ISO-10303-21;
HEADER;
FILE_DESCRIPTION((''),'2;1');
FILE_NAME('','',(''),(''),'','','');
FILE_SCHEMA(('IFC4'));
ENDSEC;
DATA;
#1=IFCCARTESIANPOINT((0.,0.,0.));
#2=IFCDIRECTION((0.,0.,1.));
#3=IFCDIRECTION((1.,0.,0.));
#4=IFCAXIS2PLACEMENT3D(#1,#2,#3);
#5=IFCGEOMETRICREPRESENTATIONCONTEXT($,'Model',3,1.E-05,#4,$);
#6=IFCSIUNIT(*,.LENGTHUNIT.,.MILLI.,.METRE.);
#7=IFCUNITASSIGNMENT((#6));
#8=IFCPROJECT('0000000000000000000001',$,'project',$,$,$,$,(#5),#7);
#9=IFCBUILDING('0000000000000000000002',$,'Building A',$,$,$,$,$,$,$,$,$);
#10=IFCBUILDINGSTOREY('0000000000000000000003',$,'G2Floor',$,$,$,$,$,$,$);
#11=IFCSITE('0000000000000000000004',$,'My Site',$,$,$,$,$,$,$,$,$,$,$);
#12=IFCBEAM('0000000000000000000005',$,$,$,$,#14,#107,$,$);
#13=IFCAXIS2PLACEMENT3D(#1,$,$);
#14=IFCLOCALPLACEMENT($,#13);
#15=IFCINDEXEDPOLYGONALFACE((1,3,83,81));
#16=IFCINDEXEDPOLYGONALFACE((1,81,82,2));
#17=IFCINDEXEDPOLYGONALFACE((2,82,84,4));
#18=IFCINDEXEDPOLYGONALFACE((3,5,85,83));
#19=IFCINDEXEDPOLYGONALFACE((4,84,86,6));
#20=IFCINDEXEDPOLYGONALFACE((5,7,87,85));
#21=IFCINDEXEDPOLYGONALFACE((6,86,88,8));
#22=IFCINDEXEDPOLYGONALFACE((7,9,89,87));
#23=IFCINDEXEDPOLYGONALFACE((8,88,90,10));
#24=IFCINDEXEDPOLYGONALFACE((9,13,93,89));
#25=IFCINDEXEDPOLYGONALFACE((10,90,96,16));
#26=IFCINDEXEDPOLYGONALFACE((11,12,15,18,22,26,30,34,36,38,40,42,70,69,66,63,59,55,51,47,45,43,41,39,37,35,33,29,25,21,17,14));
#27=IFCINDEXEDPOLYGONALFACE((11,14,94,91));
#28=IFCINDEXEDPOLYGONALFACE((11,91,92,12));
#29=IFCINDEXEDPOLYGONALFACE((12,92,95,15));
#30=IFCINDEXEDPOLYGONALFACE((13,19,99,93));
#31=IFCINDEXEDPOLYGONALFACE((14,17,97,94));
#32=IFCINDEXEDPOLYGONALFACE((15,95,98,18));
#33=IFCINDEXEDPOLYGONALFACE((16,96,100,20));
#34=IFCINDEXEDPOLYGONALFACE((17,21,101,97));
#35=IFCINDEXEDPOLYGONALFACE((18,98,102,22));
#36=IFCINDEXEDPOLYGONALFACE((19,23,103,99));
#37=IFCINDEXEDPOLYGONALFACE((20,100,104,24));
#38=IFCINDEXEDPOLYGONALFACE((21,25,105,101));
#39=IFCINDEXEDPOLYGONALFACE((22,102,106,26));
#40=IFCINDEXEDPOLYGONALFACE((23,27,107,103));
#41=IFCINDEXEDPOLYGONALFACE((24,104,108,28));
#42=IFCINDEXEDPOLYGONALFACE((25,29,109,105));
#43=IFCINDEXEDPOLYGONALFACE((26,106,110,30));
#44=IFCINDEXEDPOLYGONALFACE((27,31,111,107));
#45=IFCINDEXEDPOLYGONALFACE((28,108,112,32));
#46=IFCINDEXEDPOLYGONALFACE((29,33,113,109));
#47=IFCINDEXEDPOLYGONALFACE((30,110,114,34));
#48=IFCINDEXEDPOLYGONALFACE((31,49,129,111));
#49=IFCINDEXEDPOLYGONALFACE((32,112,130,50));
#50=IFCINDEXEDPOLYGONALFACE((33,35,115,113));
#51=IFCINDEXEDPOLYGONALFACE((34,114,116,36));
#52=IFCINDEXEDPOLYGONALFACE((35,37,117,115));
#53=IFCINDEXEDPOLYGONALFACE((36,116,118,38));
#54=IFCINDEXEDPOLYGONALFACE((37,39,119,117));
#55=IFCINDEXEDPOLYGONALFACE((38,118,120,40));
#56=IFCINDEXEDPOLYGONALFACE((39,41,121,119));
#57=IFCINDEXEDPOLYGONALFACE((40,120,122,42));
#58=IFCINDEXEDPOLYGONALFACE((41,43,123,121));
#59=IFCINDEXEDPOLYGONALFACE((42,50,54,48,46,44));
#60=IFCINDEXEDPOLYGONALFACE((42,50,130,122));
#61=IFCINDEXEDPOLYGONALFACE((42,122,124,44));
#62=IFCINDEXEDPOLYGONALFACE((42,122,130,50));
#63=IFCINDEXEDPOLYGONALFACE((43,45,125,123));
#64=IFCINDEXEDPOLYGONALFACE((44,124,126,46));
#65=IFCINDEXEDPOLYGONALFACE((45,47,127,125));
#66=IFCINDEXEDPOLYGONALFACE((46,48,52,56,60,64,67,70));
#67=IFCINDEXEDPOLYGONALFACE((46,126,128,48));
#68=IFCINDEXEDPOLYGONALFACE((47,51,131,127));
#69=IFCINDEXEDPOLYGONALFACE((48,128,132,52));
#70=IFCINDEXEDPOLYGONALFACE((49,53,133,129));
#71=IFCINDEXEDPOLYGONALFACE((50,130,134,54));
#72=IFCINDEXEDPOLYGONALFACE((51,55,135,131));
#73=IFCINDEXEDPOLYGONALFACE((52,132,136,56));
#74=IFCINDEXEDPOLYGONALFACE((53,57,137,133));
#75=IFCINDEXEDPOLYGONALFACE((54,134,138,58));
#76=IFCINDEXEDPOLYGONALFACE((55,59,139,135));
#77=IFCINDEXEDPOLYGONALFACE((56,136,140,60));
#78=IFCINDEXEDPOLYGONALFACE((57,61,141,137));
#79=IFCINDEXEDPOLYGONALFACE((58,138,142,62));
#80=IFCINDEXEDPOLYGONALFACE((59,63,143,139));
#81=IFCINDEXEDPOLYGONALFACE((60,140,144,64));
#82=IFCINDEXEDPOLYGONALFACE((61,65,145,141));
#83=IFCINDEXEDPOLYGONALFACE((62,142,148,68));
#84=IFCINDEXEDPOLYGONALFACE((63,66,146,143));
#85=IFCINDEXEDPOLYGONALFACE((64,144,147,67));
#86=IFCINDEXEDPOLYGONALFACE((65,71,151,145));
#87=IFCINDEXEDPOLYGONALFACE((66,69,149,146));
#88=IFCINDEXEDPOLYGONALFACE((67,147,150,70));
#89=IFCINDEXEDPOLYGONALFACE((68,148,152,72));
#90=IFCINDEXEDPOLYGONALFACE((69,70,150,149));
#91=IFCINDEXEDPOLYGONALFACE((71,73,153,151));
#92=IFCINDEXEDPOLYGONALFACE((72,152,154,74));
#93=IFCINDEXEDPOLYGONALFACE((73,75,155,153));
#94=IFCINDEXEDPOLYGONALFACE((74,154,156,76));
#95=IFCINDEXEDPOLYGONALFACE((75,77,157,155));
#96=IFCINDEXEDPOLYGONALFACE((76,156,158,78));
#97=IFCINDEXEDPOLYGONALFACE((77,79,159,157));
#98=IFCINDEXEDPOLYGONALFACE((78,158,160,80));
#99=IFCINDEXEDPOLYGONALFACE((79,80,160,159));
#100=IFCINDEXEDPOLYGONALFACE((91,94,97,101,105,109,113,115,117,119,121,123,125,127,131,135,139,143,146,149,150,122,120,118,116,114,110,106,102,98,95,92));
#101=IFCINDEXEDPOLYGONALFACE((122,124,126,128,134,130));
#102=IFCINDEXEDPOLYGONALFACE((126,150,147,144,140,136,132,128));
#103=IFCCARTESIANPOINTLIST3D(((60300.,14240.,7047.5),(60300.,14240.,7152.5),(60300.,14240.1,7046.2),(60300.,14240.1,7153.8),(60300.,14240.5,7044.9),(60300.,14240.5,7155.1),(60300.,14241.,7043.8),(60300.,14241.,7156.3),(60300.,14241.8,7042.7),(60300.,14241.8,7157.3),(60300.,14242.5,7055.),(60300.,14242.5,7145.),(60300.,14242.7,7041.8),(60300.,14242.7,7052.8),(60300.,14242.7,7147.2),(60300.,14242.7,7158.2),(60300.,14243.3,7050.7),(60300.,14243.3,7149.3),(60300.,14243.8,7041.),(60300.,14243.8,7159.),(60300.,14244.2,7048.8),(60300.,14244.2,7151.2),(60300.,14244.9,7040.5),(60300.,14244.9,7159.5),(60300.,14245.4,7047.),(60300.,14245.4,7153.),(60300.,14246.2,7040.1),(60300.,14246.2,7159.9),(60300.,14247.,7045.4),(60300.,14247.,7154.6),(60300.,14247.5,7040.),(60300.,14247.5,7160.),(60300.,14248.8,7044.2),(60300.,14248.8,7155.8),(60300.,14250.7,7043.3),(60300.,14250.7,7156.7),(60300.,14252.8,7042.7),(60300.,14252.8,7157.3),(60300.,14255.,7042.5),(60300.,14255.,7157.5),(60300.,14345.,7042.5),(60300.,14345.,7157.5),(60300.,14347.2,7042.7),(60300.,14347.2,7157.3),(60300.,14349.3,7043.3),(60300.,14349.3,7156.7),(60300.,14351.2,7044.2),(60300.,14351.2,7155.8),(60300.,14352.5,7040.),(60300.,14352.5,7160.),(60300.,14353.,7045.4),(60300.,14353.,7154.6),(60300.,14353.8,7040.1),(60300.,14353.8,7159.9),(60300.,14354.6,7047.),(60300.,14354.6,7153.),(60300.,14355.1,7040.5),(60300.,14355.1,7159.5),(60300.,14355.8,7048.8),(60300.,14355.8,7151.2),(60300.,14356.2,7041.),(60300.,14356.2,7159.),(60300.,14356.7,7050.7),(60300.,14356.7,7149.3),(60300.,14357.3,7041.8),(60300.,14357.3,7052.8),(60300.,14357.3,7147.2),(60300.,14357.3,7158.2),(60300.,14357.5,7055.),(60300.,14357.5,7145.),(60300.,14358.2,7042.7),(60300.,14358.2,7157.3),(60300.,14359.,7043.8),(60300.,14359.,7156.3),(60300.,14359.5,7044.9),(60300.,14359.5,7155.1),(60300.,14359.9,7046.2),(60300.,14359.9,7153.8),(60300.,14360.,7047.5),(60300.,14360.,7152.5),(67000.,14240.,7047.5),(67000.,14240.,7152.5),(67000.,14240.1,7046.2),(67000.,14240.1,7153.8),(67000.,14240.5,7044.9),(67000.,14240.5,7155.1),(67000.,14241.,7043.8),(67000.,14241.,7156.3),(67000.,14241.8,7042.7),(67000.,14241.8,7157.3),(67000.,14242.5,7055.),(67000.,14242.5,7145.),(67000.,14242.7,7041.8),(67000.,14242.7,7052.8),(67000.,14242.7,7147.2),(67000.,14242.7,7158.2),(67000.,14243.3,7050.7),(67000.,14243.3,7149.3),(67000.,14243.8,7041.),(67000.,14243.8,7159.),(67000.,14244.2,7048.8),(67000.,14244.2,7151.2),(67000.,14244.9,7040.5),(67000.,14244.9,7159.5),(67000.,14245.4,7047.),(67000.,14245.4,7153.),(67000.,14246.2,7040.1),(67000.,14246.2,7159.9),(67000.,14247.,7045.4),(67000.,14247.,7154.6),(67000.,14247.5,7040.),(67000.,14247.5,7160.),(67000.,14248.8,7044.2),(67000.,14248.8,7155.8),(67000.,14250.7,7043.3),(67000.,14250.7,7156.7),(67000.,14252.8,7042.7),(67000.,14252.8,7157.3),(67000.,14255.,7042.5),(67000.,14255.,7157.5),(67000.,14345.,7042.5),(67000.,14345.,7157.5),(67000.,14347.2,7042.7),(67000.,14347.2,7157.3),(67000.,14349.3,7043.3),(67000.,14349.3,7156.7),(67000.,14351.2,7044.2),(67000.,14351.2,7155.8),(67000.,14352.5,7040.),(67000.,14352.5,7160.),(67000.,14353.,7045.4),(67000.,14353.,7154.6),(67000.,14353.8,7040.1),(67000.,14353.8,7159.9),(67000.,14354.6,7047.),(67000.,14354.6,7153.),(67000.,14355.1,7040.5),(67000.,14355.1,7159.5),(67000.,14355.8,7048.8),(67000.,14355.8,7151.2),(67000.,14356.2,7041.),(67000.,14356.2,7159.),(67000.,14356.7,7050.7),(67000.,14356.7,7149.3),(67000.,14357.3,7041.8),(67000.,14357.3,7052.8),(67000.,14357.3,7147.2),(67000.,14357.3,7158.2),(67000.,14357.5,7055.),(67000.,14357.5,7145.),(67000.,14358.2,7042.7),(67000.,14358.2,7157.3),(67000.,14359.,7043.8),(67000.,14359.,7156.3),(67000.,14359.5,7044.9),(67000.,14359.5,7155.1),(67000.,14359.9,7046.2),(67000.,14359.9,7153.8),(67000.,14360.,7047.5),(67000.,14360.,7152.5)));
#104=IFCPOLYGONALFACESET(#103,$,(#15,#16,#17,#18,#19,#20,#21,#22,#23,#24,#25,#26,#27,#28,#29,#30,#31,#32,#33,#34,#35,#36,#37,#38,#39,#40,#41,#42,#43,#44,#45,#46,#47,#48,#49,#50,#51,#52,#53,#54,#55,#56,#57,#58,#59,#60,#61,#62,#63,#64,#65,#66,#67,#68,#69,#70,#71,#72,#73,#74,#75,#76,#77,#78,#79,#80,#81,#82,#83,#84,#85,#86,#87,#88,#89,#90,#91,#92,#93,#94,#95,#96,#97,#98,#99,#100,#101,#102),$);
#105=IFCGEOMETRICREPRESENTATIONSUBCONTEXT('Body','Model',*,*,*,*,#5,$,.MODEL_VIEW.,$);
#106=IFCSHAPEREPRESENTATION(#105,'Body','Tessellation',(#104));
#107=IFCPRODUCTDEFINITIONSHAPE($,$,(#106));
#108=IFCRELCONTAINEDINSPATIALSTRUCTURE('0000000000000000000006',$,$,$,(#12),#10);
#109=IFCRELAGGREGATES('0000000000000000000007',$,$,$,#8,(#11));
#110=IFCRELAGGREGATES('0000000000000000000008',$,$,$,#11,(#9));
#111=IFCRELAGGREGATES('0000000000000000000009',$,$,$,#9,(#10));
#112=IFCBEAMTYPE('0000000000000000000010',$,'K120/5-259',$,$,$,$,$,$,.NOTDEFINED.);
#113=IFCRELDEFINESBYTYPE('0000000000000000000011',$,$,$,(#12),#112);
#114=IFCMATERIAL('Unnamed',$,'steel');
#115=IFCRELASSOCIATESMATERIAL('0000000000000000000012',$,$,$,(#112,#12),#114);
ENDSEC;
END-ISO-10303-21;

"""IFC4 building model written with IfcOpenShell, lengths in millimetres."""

from ifc_helpers import new_model, si_unit, frame, origin_with_axes, place, context, subcontext, project, spatial, polyline, outline, extrude, material, material_profile, profile_set, profile_usage, type_object, element, save


model = new_model("IFC4")

# Units and contexts
model_context = context("Model", 3, precision=1e-05, world=origin_with_axes())
body_context = subcontext(model_context, "Body", "Model", "MODEL_VIEW")
ifc_project = project(units=[si_unit("LENGTHUNIT", "METRE", prefix="MILLI")], contexts=[model_context])

# Site, building, storey
site = spatial("IfcSite", under=ifc_project, Name="My Site")
building = spatial("IfcBuilding", under=site, Name="Building A")
storey = spatial("IfcBuildingStorey", under=building, Name="G2Floor")

# Beam
ifc_material_1 = material(Name="Unnamed", Category="steel")
ifc_material_profile_1 = material_profile(ifc_material_1, outline(polyline([(-52.5, -60.0), (52.5, -60.0), (52.5, -60.0), (53.8, -59.9), (53.8, -59.9), (55.1, -59.5), (55.1, -59.5), (56.2, -59.0), (56.2, -59.0), (57.3, -58.2), (57.3, -58.2), (58.2, -57.3), (58.2, -57.3), (59.0, -56.2), (59.0, -56.2), (59.5, -55.1), (59.5, -55.1), (59.9, -53.8), (59.9, -53.8), (60.0, -52.5), (60.0, -52.5), (60.0, 52.5), (60.0, 52.5), (59.9, 53.8), (59.9, 53.8), (59.5, 55.1), (59.5, 55.1), (59.0, 56.2), (59.0, 56.2), (58.2, 57.3), (58.2, 57.3), (57.3, 58.2), (57.3, 58.2), (56.2, 59.0), (56.2, 59.0), (55.1, 59.5), (55.1, 59.5), (53.8, 59.9), (53.8, 59.9), (52.5, 60.0), (52.5, 60.0), (-52.5, 60.0), (-52.5, 60.0), (-53.8, 59.9), (-53.8, 59.9), (-55.1, 59.5), (-55.1, 59.5), (-56.2, 59.0), (-56.2, 59.0), (-57.3, 58.2), (-57.3, 58.2), (-58.2, 57.3), (-58.2, 57.3), (-59.0, 56.2), (-59.0, 56.2), (-59.5, 55.1), (-59.5, 55.1), (-59.9, 53.8), (-59.9, 53.8), (-60.0, 52.5), (-60.0, 52.5), (-60.0, -52.5), (-60.0, -52.5), (-59.9, -53.8), (-59.9, -53.8), (-59.5, -55.1), (-59.5, -55.1), (-59.0, -56.2), (-59.0, -56.2), (-58.2, -57.3), (-58.2, -57.3), (-57.3, -58.2), (-57.3, -58.2), (-56.2, -59.0), (-56.2, -59.0), (-55.1, -59.5), (-55.1, -59.5), (-53.8, -59.9), (-53.8, -59.9), (-52.5, -60.0), (-52.5, -60.0), (-45.0, -57.5), (-45.0, -57.5), (45.0, -57.5), (45.0, -57.5), (47.2, -57.3), (47.2, -57.3), (49.3, -56.7), (49.3, -56.7), (51.2, -55.8), (51.2, -55.8), (53.0, -54.6), (53.0, -54.6), (54.6, -53.0), (54.6, -53.0), (55.8, -51.2), (55.8, -51.2), (56.7, -49.3), (56.7, -49.3), (57.3, -47.2), (57.3, -47.2), (57.5, -45.0), (57.5, -45.0), (57.5, 45.0), (57.5, 45.0), (57.3, 47.2), (57.3, 47.2), (56.7, 49.3), (56.7, 49.3), (55.8, 51.2), (55.8, 51.2), (54.6, 53.0), (54.6, 53.0), (53.0, 54.6), (53.0, 54.6), (51.2, 55.8), (51.2, 55.8), (49.3, 56.7), (49.3, 56.7), (47.2, 57.3), (47.2, 57.3), (45.0, 57.5), (45.0, 57.5), (-45.0, 57.5), (-45.0, 57.5), (-47.2, 57.3), (-47.2, 57.3), (-49.3, 56.7), (-49.3, 56.7), (-51.2, 55.8), (-51.2, 55.8), (-53.0, 54.6), (-53.0, 54.6), (-54.6, 53.0), (-54.6, 53.0), (-55.8, 51.2), (-55.8, 51.2), (-56.7, 49.3), (-56.7, 49.3), (-57.3, 47.2), (-57.3, 47.2), (-57.5, 45.0), (-57.5, 45.0), (-57.5, -45.0), (-57.5, -45.0), (-57.3, -47.2), (-57.3, -47.2), (-56.7, -49.3), (-56.7, -49.3), (-55.8, -51.2), (-55.8, -51.2), (-54.6, -53.0), (-54.6, -53.0), (-53.0, -54.6), (-53.0, -54.6), (-51.2, -55.8), (-51.2, -55.8), (-49.3, -56.7), (-49.3, -56.7), (-47.2, -57.3), (-47.2, -57.3), (-45.0, -57.5), (-45.0, -57.5), (-52.5, -60.0)])))
ifc_profile_set_1 = profile_set([ifc_material_profile_1], Name="K120/5-259")
ifc_profile_usage_1 = profile_usage(ifc_profile_set_1)
beam_type_1 = type_object("IfcBeamType", Name="K120/5-259", PredefinedType="NOTDEFINED", material=ifc_profile_set_1)
beam_1_placement = place(None, frame((60300.0, 14300.0, 7100.0), z_axis=(1.0, 0.0, 0.0), x_axis=(0.0, -1.0, 0.0)))
element("IfcBeam", 1, at=beam_1_placement, inside=storey, type_object=beam_type_1, material=ifc_profile_usage_1, context=body_context, shape_type="SweptSolid", body=[
    extrude(outline(polyline([(-52.5, -60.0), (52.5, -60.0), (52.5, -60.0), (53.8, -59.9), (53.8, -59.9), (55.1, -59.5), (55.1, -59.5), (56.2, -59.0), (56.2, -59.0), (57.3, -58.2), (57.3, -58.2), (58.2, -57.3), (58.2, -57.3), (59.0, -56.2), (59.0, -56.2), (59.5, -55.1), (59.5, -55.1), (59.9, -53.8), (59.9, -53.8), (60.0, -52.5), (60.0, -52.5), (60.0, 52.5), (60.0, 52.5), (59.9, 53.8), (59.9, 53.8), (59.5, 55.1), (59.5, 55.1), (59.0, 56.2), (59.0, 56.2), (58.2, 57.3), (58.2, 57.3), (57.3, 58.2), (57.3, 58.2), (56.2, 59.0), (56.2, 59.0), (55.1, 59.5), (55.1, 59.5), (53.8, 59.9), (53.8, 59.9), (52.5, 60.0), (52.5, 60.0), (-52.5, 60.0), (-52.5, 60.0), (-53.8, 59.9), (-53.8, 59.9), (-55.1, 59.5), (-55.1, 59.5), (-56.2, 59.0), (-56.2, 59.0), (-57.3, 58.2), (-57.3, 58.2), (-58.2, 57.3), (-58.2, 57.3), (-59.0, 56.2), (-59.0, 56.2), (-59.5, 55.1), (-59.5, 55.1), (-59.9, 53.8), (-59.9, 53.8), (-60.0, 52.5), (-60.0, 52.5), (-60.0, -52.5), (-60.0, -52.5), (-59.9, -53.8), (-59.9, -53.8), (-59.5, -55.1), (-59.5, -55.1), (-59.0, -56.2), (-59.0, -56.2), (-58.2, -57.3), (-58.2, -57.3), (-57.3, -58.2), (-57.3, -58.2), (-56.2, -59.0), (-56.2, -59.0), (-55.1, -59.5), (-55.1, -59.5), (-53.8, -59.9), (-53.8, -59.9), (-52.5, -60.0), (-52.5, -60.0), (-45.0, -57.5), (-45.0, -57.5), (45.0, -57.5), (45.0, -57.5), (47.2, -57.3), (47.2, -57.3), (49.3, -56.7), (49.3, -56.7), (51.2, -55.8), (51.2, -55.8), (53.0, -54.6), (53.0, -54.6), (54.6, -53.0), (54.6, -53.0), (55.8, -51.2), (55.8, -51.2), (56.7, -49.3), (56.7, -49.3), (57.3, -47.2), (57.3, -47.2), (57.5, -45.0), (57.5, -45.0), (57.5, 45.0), (57.5, 45.0), (57.3, 47.2), (57.3, 47.2), (56.7, 49.3), (56.7, 49.3), (55.8, 51.2), (55.8, 51.2), (54.6, 53.0), (54.6, 53.0), (53.0, 54.6), (53.0, 54.6), (51.2, 55.8), (51.2, 55.8), (49.3, 56.7), (49.3, 56.7), (47.2, 57.3), (47.2, 57.3), (45.0, 57.5), (45.0, 57.5), (-45.0, 57.5), (-45.0, 57.5), (-47.2, 57.3), (-47.2, 57.3), (-49.3, 56.7), (-49.3, 56.7), (-51.2, 55.8), (-51.2, 55.8), (-53.0, 54.6), (-53.0, 54.6), (-54.6, 53.0), (-54.6, 53.0), (-55.8, 51.2), (-55.8, 51.2), (-56.7, 49.3), (-56.7, 49.3), (-57.3, 47.2), (-57.3, 47.2), (-57.5, 45.0), (-57.5, 45.0), (-57.5, -45.0), (-57.5, -45.0), (-57.3, -47.2), (-57.3, -47.2), (-56.7, -49.3), (-56.7, -49.3), (-55.8, -51.2), (-55.8, -51.2), (-54.6, -53.0), (-54.6, -53.0), (-53.0, -54.6), (-53.0, -54.6), (-51.2, -55.8), (-51.2, -55.8), (-49.3, -56.7), (-49.3, -56.7), (-47.2, -57.3), (-47.2, -57.3), (-45.0, -57.5), (-45.0, -57.5), (-52.5, -60.0)])), origin_with_axes(), (0.0, 0.0, 1.0), 6700.0),
])

save(model, "model.ifc")
